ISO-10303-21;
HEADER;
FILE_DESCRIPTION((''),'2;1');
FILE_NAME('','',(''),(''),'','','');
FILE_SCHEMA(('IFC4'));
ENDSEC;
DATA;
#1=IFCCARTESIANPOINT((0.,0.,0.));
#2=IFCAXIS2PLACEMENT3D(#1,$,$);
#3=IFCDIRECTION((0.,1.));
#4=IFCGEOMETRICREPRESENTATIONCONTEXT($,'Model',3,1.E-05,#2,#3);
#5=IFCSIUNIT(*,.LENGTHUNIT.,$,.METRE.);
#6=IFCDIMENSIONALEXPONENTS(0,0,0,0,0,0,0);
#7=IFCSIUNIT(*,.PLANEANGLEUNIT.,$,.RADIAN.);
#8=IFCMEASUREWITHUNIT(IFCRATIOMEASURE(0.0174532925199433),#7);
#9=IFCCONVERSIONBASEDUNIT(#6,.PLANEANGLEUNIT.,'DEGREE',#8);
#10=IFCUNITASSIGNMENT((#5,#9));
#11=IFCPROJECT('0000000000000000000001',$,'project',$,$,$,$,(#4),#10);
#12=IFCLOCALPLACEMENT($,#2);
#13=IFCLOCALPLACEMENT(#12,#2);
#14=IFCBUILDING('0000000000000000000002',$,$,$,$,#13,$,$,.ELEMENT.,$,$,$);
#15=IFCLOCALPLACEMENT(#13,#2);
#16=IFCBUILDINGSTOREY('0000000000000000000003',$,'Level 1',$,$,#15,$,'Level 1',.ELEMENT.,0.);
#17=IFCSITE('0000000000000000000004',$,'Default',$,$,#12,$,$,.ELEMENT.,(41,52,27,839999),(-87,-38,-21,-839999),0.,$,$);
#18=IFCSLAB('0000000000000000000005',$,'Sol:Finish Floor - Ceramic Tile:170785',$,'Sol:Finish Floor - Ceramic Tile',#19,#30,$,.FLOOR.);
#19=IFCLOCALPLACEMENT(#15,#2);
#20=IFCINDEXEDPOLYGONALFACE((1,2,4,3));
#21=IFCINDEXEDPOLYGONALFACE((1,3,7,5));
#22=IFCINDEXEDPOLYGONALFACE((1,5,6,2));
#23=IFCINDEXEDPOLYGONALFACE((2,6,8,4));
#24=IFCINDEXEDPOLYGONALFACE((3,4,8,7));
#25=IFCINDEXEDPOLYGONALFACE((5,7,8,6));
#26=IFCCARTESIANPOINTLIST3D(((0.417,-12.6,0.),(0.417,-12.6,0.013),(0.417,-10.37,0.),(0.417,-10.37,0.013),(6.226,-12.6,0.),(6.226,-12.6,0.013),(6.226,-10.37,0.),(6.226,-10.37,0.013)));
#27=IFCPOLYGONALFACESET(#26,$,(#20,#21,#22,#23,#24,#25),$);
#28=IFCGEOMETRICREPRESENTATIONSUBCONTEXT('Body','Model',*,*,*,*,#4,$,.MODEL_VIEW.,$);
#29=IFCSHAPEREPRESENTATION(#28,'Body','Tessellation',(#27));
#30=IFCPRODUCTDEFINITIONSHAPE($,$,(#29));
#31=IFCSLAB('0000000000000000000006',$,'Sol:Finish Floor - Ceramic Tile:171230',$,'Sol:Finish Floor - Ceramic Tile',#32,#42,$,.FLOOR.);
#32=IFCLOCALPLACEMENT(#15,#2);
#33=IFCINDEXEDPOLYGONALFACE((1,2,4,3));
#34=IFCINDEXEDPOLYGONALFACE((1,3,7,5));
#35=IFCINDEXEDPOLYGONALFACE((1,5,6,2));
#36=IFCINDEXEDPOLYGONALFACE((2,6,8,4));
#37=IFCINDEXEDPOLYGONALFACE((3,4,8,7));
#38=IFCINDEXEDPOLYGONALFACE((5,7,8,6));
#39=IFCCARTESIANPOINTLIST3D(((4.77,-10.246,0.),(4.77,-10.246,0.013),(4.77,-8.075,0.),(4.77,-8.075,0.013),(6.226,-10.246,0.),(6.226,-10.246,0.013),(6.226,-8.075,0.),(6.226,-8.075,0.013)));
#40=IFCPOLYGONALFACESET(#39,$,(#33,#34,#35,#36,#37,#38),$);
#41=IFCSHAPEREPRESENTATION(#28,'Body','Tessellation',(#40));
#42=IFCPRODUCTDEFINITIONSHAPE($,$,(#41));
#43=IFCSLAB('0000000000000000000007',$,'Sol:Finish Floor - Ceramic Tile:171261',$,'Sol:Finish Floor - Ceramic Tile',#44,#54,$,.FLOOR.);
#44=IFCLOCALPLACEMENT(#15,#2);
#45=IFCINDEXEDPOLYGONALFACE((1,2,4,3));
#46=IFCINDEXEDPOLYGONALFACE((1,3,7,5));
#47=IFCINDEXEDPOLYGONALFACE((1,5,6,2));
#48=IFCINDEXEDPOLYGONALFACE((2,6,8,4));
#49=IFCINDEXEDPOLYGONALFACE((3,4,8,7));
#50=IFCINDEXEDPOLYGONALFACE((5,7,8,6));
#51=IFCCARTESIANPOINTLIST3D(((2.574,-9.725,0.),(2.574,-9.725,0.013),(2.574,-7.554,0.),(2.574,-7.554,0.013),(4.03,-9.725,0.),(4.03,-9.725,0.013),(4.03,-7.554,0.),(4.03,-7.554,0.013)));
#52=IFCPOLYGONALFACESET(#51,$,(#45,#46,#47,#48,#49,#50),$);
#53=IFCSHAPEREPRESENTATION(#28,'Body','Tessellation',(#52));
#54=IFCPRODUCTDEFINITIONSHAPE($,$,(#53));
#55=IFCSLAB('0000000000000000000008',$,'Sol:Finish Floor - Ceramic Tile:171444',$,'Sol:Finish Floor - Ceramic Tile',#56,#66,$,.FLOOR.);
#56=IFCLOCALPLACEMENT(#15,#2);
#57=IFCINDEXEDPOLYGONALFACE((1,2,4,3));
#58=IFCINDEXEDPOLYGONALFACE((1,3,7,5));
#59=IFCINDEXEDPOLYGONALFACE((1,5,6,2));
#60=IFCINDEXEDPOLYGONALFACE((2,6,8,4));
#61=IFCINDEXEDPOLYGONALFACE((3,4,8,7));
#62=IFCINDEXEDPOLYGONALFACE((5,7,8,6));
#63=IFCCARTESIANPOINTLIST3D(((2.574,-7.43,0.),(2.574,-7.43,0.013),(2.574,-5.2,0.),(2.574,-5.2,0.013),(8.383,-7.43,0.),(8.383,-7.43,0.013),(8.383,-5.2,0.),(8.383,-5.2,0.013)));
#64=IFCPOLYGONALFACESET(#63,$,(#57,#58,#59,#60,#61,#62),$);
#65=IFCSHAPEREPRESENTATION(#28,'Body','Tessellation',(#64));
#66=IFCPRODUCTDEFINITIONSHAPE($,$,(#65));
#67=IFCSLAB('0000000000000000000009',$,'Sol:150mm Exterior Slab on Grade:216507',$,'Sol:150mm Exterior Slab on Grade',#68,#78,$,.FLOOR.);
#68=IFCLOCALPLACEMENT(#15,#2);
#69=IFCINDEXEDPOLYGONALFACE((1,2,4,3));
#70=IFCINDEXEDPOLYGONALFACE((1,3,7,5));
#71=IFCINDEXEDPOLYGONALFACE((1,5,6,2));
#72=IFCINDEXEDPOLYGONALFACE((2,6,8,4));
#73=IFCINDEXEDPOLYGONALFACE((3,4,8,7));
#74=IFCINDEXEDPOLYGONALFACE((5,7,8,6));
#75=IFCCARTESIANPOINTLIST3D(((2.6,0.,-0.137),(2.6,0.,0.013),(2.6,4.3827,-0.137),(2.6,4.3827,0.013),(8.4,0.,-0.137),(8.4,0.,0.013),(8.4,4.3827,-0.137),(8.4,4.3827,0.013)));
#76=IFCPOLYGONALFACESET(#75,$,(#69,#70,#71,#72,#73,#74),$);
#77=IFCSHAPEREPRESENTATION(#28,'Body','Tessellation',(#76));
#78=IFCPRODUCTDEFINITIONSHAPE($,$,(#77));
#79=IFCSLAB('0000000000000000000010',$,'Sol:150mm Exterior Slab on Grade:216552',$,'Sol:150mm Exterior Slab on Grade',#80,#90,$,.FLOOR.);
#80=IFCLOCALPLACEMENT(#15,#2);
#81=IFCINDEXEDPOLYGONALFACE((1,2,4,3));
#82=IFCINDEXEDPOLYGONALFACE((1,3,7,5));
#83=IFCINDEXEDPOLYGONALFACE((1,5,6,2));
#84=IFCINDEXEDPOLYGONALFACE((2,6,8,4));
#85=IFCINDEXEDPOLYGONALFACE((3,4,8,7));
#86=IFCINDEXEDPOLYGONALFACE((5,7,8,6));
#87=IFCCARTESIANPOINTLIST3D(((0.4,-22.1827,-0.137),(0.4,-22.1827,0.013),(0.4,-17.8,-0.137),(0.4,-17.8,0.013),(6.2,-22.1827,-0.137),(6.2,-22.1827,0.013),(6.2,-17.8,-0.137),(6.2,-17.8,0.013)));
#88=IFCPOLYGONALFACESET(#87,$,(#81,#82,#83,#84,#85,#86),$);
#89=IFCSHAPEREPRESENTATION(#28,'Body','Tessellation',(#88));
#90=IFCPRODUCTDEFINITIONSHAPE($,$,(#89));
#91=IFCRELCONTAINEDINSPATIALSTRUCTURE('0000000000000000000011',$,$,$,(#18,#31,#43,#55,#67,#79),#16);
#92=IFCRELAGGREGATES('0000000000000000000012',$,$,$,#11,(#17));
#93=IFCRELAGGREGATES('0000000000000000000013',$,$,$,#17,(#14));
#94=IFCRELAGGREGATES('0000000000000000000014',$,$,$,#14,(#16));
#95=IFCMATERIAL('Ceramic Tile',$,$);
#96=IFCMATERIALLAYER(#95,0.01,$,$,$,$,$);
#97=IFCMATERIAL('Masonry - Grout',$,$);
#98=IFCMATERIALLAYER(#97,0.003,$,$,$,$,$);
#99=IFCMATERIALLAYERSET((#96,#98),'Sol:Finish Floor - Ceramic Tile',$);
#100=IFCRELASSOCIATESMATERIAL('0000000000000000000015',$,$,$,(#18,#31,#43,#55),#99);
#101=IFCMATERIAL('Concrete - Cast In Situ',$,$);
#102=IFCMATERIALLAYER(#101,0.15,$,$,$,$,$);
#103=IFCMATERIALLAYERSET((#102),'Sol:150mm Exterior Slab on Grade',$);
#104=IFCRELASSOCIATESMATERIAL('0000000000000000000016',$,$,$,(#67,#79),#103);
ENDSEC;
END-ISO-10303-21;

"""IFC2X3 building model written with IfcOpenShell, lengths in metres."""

from ifc_helpers import new_model, entity, si_unit, converted_unit, direction, frame, frame_2d, origin, place, context, subcontext, project, spatial, rectangle, extrude, material, layer, layer_set, layer_usage, element, save


model = new_model("IFC2X3")

# Units and contexts
model_context = context("Model", 3, precision=1e-05, world=origin(), true_north=direction((0.0, 1.0)))
body_context = subcontext(model_context, "Body", "Model", "MODEL_VIEW")
ifc_project = project(units=[si_unit("LENGTHUNIT", "METRE"), converted_unit("PLANEANGLEUNIT", "DEGREE", entity("IfcRatioMeasure", 0.0174532925199433), si_unit("PLANEANGLEUNIT", "RADIAN"), dimensions=[0, 0, 0, 0, 0, 0, 0])], contexts=[model_context])

# Site, building, storey
site_placement = place(None, origin())
site = spatial("IfcSite", under=ifc_project, at=site_placement, Name="Default", CompositionType="ELEMENT", RefLatitude=(41, 52, 27, 839999), RefLongitude=(-87, -38, -21, -839999), RefElevation=0.0)
building_placement = place(site_placement, origin())
building = spatial("IfcBuilding", under=site, at=building_placement, CompositionType="ELEMENT")
storey_placement = place(building_placement, origin())
storey = spatial("IfcBuildingStorey", under=building, at=storey_placement, Name="Level 1", LongName="Level 1", CompositionType="ELEMENT", Elevation=0.0)

# Slabs
ifc_material_1 = material(Name="Ceramic Tile")
ifc_layer_1 = layer(ifc_material_1, 0.01)
ifc_material_2 = material(Name="Masonry - Grout")
ifc_layer_2 = layer(ifc_material_2, 0.003)
ifc_layer_set_1 = layer_set([ifc_layer_1, ifc_layer_2], Name="Sol:Finish Floor - Ceramic Tile")
ifc_layer_usage_1 = layer_usage(ifc_layer_set_1, "AXIS3", "POSITIVE", 0.0)
slab_1_placement = place(storey_placement, origin())
element("IfcSlab", 1, at=slab_1_placement, inside=storey, material=ifc_layer_usage_1, Name="Sol:Finish Floor - Ceramic Tile:170785", ObjectType="Sol:Finish Floor - Ceramic Tile", PredefinedType="FLOOR", context=body_context, shape_type="SweptSolid", body=[
    extrude(rectangle(XDim=2.23, YDim=5.809, at=frame_2d((0.0, 0.0), x_axis=(1.0, 0.0))), frame((3.3215, -11.485, 0.013), z_axis=(0.0, 0.0, -1.0), x_axis=(0.0, 1.0, 0.0)), (0.0, 0.0, 1.0), 0.013),
])
ifc_layer_usage_2 = layer_usage(ifc_layer_set_1, "AXIS3", "POSITIVE", 0.0)
slab_2_placement = place(storey_placement, origin())
element("IfcSlab", 2, at=slab_2_placement, inside=storey, material=ifc_layer_usage_2, Name="Sol:Finish Floor - Ceramic Tile:171230", ObjectType="Sol:Finish Floor - Ceramic Tile", PredefinedType="FLOOR", context=body_context, shape_type="SweptSolid", body=[
    extrude(rectangle(XDim=2.171, YDim=1.456, at=frame_2d((0.0, 0.0), x_axis=(1.0, 0.0))), frame((5.498, -9.1605, 0.013), z_axis=(0.0, 0.0, -1.0), x_axis=(0.0, 1.0, 0.0)), (0.0, 0.0, 1.0), 0.013),
])
ifc_layer_usage_3 = layer_usage(ifc_layer_set_1, "AXIS3", "POSITIVE", 0.0)
slab_3_placement = place(storey_placement, origin())
element("IfcSlab", 3, at=slab_3_placement, inside=storey, material=ifc_layer_usage_3, Name="Sol:Finish Floor - Ceramic Tile:171261", ObjectType="Sol:Finish Floor - Ceramic Tile", PredefinedType="FLOOR", context=body_context, shape_type="SweptSolid", body=[
    extrude(rectangle(XDim=2.171, YDim=1.456, at=frame_2d((0.0, 0.0), x_axis=(1.0, 0.0))), frame((3.302, -8.6395, 0.013), z_axis=(0.0, 0.0, -1.0), x_axis=(0.0, 1.0, 0.0)), (0.0, 0.0, 1.0), 0.013),
])
ifc_layer_usage_4 = layer_usage(ifc_layer_set_1, "AXIS3", "POSITIVE", 0.0)
slab_4_placement = place(storey_placement, origin())
element("IfcSlab", 4, at=slab_4_placement, inside=storey, material=ifc_layer_usage_4, Name="Sol:Finish Floor - Ceramic Tile:171444", ObjectType="Sol:Finish Floor - Ceramic Tile", PredefinedType="FLOOR", context=body_context, shape_type="SweptSolid", body=[
    extrude(rectangle(XDim=2.23, YDim=5.809, at=frame_2d((0.0, 0.0), x_axis=(1.0, 0.0))), frame((5.4785, -6.315, 0.013), z_axis=(0.0, 0.0, -1.0), x_axis=(0.0, 1.0, 0.0)), (0.0, 0.0, 1.0), 0.013),
])
ifc_material_3 = material(Name="Concrete - Cast In Situ")
ifc_layer_3 = layer(ifc_material_3, 0.15)
ifc_layer_set_2 = layer_set([ifc_layer_3], Name="Sol:150mm Exterior Slab on Grade")
ifc_layer_usage_5 = layer_usage(ifc_layer_set_2, "AXIS3", "POSITIVE", 0.0)
slab_5_placement = place(storey_placement, origin())
element("IfcSlab", 5, at=slab_5_placement, inside=storey, material=ifc_layer_usage_5, Name="Sol:150mm Exterior Slab on Grade:216507", ObjectType="Sol:150mm Exterior Slab on Grade", PredefinedType="FLOOR", context=body_context, shape_type="SweptSolid", body=[
    extrude(rectangle(XDim=4.3827, YDim=5.8, at=frame_2d((0.0, 0.0), x_axis=(1.0, 0.0))), frame((5.5, 2.1914, 0.013), z_axis=(0.0, 0.0, -1.0), x_axis=(0.0, 1.0, 0.0)), (0.0, 0.0, 1.0), 0.15),
])
ifc_layer_usage_6 = layer_usage(ifc_layer_set_2, "AXIS3", "POSITIVE", 0.0)
slab_6_placement = place(storey_placement, origin())
element("IfcSlab", 6, at=slab_6_placement, inside=storey, material=ifc_layer_usage_6, Name="Sol:150mm Exterior Slab on Grade:216552", ObjectType="Sol:150mm Exterior Slab on Grade", PredefinedType="FLOOR", context=body_context, shape_type="SweptSolid", body=[
    extrude(rectangle(XDim=4.3827, YDim=5.8, at=frame_2d((0.0, 0.0), x_axis=(1.0, 0.0))), frame((3.3, -19.9914, 0.013), z_axis=(0.0, 0.0, -1.0), x_axis=(0.0, 1.0, 0.0)), (0.0, 0.0, 1.0), 0.15),
])

save(model, "model.ifc")
